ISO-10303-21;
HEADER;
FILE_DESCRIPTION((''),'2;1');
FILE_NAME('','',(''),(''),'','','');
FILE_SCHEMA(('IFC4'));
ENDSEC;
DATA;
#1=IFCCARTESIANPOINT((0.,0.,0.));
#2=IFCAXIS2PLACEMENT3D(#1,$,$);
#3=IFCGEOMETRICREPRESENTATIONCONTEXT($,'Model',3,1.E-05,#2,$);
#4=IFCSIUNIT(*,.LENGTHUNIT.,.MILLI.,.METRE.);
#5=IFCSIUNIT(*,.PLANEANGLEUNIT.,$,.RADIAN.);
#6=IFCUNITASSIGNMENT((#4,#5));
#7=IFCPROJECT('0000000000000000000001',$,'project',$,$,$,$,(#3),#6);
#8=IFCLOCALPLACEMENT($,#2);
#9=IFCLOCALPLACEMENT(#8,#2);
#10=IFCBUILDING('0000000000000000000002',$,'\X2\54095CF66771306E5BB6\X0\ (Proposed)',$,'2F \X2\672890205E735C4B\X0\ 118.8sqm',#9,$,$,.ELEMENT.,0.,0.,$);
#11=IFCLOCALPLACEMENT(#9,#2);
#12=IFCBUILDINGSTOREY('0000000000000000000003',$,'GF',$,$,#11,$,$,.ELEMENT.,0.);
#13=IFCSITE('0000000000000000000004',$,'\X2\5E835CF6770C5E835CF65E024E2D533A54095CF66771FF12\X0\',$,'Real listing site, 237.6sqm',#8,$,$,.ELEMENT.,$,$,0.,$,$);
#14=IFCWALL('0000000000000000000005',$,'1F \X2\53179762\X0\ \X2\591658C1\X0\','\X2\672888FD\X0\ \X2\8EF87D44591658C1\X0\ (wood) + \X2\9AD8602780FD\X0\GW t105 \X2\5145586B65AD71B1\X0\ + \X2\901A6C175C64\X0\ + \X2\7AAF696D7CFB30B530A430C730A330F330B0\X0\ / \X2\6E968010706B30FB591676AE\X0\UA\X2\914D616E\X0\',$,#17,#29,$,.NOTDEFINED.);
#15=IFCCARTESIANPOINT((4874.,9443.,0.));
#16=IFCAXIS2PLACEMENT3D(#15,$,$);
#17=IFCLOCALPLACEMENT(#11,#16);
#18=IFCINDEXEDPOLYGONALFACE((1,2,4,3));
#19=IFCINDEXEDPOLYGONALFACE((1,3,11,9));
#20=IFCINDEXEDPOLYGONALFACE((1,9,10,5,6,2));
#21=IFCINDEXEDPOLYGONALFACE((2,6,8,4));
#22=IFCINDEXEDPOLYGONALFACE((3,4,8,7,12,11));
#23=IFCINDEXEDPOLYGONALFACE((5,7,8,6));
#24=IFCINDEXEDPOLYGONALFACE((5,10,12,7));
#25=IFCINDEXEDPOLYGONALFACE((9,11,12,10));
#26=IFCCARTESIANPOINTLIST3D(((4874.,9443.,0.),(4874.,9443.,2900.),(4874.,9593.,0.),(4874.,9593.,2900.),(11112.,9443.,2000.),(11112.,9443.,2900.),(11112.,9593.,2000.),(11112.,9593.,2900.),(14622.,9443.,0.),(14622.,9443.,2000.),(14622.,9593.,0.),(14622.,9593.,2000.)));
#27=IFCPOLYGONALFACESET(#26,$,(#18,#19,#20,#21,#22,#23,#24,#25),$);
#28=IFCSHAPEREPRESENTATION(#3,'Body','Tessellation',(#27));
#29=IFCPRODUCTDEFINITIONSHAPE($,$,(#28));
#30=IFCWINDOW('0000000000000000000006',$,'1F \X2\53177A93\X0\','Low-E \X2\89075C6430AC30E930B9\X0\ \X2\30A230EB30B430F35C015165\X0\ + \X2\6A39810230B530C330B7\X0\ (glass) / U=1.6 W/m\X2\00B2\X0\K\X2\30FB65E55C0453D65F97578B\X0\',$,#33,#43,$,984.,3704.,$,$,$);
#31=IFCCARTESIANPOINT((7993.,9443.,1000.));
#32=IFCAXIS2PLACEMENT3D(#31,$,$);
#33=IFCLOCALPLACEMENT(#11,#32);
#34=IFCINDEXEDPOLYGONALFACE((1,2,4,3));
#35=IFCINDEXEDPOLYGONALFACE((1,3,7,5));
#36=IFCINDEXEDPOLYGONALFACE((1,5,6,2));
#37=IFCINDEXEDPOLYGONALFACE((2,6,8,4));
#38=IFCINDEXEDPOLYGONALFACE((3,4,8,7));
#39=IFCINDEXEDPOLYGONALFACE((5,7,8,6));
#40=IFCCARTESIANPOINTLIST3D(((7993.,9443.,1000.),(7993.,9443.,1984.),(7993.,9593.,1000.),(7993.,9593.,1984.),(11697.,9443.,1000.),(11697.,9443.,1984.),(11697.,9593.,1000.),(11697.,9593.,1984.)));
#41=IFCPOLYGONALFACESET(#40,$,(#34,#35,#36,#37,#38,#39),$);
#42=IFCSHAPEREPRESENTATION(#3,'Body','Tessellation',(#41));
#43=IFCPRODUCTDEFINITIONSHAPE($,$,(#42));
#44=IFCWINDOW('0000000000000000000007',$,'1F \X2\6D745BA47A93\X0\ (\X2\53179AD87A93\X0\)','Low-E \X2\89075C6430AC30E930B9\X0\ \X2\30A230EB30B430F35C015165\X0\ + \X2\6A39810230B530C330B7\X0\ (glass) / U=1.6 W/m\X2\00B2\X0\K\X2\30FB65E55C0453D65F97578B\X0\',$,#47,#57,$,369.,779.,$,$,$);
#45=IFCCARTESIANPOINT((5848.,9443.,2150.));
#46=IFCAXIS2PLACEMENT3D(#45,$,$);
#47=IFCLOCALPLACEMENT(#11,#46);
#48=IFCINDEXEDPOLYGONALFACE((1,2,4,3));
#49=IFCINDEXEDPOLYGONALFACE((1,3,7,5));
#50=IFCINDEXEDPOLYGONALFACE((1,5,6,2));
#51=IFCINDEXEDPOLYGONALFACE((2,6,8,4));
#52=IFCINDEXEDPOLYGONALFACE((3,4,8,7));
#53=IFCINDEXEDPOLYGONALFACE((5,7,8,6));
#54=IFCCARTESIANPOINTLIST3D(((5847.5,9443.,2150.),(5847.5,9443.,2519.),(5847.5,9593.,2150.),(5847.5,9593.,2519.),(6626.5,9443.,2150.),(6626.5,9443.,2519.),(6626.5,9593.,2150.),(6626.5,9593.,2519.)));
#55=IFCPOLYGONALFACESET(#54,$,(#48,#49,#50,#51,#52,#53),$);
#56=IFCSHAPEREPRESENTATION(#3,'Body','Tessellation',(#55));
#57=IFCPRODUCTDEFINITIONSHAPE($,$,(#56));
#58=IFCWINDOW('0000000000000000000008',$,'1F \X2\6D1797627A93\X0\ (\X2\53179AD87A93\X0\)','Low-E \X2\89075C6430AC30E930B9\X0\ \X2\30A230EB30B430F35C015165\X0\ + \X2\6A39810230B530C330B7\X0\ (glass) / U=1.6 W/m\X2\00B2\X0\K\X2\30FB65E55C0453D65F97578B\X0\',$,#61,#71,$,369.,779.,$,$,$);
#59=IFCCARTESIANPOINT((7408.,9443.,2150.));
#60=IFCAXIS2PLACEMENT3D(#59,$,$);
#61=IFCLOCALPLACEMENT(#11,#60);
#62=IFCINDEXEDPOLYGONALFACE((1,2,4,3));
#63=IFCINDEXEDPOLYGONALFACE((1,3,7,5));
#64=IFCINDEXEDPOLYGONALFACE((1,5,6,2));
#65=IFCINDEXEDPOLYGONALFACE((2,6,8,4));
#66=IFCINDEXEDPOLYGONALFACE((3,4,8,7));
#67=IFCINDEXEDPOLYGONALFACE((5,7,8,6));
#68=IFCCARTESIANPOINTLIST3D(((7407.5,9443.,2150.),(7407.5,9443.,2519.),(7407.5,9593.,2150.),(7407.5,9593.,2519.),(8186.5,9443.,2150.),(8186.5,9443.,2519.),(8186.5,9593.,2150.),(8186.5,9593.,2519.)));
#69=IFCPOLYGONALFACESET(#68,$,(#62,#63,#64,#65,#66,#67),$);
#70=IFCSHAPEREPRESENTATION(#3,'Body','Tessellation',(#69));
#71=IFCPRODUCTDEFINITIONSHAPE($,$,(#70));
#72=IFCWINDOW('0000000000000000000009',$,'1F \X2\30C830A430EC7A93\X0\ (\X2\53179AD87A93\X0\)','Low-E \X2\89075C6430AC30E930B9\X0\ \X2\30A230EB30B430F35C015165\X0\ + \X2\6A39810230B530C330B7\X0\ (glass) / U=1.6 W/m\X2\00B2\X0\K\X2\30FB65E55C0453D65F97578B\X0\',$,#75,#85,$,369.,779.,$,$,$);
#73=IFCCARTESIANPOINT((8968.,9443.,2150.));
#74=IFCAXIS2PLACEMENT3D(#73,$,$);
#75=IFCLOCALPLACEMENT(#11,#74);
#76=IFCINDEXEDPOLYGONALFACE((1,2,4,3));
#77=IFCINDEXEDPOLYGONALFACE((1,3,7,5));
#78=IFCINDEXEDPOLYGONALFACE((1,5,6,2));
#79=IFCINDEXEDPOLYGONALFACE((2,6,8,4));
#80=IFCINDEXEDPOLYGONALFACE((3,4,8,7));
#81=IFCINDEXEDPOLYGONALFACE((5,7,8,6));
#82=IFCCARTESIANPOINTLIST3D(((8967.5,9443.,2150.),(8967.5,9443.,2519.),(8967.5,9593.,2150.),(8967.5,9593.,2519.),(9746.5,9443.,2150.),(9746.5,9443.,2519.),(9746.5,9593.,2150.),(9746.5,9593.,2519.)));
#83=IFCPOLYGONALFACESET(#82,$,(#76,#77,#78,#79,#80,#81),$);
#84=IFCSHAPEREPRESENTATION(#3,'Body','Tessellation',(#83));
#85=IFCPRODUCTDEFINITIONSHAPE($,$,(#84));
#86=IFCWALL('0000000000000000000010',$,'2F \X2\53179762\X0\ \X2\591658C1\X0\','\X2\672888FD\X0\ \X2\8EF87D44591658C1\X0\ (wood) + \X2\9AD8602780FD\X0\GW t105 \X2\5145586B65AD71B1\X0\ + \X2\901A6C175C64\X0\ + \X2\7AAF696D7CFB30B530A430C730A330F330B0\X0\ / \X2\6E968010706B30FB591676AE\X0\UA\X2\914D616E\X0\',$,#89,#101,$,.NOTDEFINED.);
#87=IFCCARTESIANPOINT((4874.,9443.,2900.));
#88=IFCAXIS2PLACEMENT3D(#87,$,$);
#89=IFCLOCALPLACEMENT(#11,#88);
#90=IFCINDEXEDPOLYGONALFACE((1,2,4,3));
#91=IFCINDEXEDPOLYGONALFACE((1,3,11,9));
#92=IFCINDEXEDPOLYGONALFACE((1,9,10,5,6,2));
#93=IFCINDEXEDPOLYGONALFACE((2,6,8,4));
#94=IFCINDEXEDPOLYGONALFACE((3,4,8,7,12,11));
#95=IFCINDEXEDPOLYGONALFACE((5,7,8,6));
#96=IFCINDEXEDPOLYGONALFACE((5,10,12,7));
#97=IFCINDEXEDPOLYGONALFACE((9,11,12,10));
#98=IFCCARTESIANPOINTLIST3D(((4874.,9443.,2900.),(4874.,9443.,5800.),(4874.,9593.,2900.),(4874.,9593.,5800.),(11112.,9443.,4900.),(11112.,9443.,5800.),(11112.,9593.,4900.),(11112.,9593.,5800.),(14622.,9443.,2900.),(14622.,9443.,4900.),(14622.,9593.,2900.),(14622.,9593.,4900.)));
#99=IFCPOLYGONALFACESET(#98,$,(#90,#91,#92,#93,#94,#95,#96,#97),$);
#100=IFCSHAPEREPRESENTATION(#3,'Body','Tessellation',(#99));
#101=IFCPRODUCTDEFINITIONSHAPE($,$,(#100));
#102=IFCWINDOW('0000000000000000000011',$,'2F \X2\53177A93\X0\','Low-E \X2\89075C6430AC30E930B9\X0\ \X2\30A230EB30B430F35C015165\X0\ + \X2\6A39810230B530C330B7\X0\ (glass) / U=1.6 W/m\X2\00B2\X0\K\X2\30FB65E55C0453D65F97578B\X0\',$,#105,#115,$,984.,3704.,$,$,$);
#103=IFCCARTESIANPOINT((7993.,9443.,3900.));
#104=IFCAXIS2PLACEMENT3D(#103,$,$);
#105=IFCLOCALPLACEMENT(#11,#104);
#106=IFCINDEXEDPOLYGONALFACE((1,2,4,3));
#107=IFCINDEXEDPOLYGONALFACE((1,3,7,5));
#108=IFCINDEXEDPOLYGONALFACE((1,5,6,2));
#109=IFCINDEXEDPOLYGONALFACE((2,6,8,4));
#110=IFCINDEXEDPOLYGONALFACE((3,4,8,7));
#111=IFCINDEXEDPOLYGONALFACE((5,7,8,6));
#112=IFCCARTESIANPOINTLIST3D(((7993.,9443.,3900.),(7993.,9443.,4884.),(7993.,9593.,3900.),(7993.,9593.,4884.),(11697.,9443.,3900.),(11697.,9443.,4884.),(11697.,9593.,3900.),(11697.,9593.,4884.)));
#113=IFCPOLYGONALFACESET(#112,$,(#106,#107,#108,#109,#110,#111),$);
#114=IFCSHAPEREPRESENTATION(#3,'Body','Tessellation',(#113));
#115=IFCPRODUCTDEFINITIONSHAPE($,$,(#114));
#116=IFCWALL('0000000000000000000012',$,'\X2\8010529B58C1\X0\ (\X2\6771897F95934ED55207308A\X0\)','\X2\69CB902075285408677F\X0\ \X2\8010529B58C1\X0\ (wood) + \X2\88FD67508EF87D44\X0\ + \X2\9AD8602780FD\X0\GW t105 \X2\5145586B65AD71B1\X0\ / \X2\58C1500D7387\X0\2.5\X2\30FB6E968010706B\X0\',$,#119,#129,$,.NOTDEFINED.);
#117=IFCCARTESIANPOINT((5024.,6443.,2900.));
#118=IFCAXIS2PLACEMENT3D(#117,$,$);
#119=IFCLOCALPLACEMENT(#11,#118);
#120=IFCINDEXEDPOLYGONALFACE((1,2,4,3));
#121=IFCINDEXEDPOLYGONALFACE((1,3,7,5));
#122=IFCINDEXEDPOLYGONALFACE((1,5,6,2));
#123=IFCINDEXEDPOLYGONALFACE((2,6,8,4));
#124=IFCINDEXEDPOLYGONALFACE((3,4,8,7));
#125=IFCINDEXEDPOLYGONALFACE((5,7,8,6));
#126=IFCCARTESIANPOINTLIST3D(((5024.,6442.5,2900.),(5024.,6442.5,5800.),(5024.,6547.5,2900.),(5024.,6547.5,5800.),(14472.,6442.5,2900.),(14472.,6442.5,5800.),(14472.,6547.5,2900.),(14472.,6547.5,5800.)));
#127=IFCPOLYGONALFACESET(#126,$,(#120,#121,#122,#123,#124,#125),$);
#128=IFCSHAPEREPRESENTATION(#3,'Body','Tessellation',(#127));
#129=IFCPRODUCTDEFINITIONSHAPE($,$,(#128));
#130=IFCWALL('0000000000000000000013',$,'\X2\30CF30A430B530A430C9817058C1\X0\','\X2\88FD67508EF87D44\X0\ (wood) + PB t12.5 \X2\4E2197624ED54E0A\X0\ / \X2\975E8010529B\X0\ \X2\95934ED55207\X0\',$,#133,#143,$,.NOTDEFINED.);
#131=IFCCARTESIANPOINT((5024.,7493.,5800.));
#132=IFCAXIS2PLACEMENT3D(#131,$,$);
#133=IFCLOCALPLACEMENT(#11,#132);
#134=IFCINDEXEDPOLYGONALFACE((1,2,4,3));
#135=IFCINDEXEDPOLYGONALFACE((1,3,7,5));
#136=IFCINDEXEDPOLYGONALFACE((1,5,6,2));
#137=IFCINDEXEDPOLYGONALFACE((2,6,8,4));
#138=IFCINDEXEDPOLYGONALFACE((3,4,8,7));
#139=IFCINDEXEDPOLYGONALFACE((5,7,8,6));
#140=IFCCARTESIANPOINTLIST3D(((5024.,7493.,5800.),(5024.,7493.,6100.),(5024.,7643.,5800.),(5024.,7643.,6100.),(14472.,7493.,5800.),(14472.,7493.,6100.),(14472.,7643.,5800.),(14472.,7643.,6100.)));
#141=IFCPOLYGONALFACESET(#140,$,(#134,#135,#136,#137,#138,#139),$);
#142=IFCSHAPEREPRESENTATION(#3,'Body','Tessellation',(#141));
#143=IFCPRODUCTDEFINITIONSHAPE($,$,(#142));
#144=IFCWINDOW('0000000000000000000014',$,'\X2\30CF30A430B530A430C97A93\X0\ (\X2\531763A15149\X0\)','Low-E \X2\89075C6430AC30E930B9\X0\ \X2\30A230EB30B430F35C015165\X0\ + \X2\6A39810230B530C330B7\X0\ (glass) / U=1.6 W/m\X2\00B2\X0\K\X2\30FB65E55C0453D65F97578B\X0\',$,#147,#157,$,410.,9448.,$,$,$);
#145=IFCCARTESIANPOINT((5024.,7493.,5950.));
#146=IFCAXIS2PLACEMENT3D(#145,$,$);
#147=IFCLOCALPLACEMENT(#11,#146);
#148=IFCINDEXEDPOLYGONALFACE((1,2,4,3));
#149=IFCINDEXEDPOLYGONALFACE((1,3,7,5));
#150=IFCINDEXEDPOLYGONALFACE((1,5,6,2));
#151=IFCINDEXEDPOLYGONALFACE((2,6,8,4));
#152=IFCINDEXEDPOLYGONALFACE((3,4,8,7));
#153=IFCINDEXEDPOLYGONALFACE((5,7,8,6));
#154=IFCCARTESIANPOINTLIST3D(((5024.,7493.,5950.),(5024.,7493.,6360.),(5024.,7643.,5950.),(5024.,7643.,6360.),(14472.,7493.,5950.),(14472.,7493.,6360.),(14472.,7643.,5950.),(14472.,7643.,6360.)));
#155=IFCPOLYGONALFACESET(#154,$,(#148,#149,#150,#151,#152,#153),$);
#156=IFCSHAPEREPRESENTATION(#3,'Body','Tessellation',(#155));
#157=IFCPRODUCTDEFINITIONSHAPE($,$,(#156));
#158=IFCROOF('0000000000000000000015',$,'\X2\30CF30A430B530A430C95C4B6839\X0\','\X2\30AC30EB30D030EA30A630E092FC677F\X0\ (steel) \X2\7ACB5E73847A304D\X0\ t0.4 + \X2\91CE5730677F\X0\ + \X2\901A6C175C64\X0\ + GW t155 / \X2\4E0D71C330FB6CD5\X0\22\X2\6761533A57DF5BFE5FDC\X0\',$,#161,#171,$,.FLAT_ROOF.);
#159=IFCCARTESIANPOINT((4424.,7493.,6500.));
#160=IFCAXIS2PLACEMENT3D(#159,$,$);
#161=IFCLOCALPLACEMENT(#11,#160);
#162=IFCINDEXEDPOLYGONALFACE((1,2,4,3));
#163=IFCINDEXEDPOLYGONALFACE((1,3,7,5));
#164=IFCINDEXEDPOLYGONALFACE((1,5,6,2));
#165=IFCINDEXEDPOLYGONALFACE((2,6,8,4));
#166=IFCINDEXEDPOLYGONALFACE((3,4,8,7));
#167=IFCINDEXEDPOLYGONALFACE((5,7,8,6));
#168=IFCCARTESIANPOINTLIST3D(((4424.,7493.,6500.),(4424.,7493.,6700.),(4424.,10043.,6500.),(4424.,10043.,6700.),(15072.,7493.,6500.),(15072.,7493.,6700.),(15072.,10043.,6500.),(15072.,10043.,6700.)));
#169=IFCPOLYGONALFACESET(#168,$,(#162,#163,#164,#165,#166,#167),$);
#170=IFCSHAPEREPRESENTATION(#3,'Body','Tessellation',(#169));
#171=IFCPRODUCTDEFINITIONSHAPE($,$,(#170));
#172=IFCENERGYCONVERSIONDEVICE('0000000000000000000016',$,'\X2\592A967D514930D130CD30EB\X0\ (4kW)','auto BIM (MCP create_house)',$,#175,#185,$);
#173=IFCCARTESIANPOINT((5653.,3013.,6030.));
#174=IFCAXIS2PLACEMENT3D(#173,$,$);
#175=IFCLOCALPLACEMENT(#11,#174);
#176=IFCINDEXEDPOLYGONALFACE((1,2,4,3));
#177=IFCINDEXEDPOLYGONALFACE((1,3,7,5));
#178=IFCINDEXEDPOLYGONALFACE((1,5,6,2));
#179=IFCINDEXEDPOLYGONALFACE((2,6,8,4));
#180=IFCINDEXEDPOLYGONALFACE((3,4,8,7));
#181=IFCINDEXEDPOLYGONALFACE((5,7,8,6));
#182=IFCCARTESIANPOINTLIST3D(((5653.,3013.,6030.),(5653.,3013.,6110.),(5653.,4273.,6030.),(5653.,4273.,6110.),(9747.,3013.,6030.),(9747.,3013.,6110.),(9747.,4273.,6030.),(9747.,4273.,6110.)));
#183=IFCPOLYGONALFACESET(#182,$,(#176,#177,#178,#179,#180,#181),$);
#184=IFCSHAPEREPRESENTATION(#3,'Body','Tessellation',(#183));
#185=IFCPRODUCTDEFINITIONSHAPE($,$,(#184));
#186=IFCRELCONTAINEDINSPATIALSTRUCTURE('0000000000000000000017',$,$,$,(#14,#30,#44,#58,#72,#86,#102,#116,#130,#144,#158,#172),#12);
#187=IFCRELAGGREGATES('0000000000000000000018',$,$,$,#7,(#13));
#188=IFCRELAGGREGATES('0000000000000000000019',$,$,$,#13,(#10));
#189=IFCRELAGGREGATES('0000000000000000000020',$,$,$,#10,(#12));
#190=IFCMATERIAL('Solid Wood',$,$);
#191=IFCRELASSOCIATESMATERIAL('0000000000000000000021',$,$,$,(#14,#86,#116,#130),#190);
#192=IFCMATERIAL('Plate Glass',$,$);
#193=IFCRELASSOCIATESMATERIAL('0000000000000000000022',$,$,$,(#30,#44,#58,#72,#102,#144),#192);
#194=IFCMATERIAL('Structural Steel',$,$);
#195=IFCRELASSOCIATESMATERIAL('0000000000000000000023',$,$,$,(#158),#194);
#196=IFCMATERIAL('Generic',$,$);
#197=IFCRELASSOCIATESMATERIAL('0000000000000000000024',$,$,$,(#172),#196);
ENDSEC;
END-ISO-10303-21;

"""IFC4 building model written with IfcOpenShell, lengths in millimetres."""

from ifc_helpers import new_model, si_unit, frame, frame_2d, origin, place, context, project, spatial, rectangle, extrude, material, element, fill, save


model = new_model("IFC4")

# Units and contexts
model_context = context("Model", 3, precision=1e-05, world=origin())
ifc_project = project(units=[si_unit("LENGTHUNIT", "METRE", prefix="MILLI"), si_unit("PLANEANGLEUNIT", "RADIAN")], contexts=[model_context])

# Site, building, storey
site_placement = place(None, origin())
site = spatial("IfcSite", under=ifc_project, at=site_placement, Name="広島県広島市中区吉島東２", ObjectType="Real listing site, 237.6sqm", CompositionType="ELEMENT", RefElevation=0.0)
building_placement = place(site_placement, origin())
building = spatial("IfcBuilding", under=site, at=building_placement, Name="吉島東の家 (Proposed)", ObjectType="2F 木造平屋 118.8sqm", CompositionType="ELEMENT", ElevationOfRefHeight=0.0, ElevationOfTerrain=0.0)
storey_placement = place(building_placement, origin())
storey = spatial("IfcBuildingStorey", under=building, at=storey_placement, Name="GF", CompositionType="ELEMENT", Elevation=0.0)

# Wall, openings, windows
ifc_material_1 = material(Name="Solid Wood")
wall_1_placement = place(storey_placement, frame((4874.0, 9443.0, 0.0)))
wall_1 = element("IfcWall", 1, at=wall_1_placement, inside=storey, material=ifc_material_1, Name="1F 北面 外壁", Description="木製 軸組外壁 (wood) + 高性能GW t105 充填断熱 + 通気層 + 窯業系サイディング / 準耐火・外皮UA配慮", PredefinedType="NOTDEFINED", context=model_context, shape_type="SweptSolid", body=[
    extrude(rectangle(XDim=9748.0, YDim=150.0, at=frame_2d((4874.0, 75.0))), frame((4874.0, 9443.0, 0.0)), (0.0, 0.0, 1.0), 2900.0),
])
opening_1_placement = place(storey_placement, frame((7993.0, 9443.0, 1000.0)))
opening_1 = element("IfcOpeningElement", 2, at=opening_1_placement, cuts=wall_1, PredefinedType="NOTDEFINED", context=model_context, shape_type="SweptSolid", body=[
    extrude(rectangle(XDim=3704.0, YDim=150.0, at=frame_2d((1852.0, 75.0))), frame((7993.0, 9443.0, 1000.0)), (0.0, 0.0, 1.0), 984.0),
])
opening_2_placement = place(storey_placement, frame((5848.0, 9443.0, 2150.0)))
opening_2 = element("IfcOpeningElement", 3, at=opening_2_placement, cuts=wall_1, PredefinedType="NOTDEFINED", context=model_context, shape_type="SweptSolid", body=[
    extrude(rectangle(XDim=779.0, YDim=150.0, at=frame_2d((389.0, 75.0))), frame((5848.0, 9443.0, 2150.0)), (0.0, 0.0, 1.0), 369.0),
])
opening_3_placement = place(storey_placement, frame((7408.0, 9443.0, 2150.0)))
opening_3 = element("IfcOpeningElement", 4, at=opening_3_placement, cuts=wall_1, PredefinedType="NOTDEFINED", context=model_context, shape_type="SweptSolid", body=[
    extrude(rectangle(XDim=779.0, YDim=150.0, at=frame_2d((389.0, 75.0))), frame((7408.0, 9443.0, 2150.0)), (0.0, 0.0, 1.0), 369.0),
])
opening_4_placement = place(storey_placement, frame((8968.0, 9443.0, 2150.0)))
opening_4 = element("IfcOpeningElement", 5, at=opening_4_placement, cuts=wall_1, PredefinedType="NOTDEFINED", context=model_context, shape_type="SweptSolid", body=[
    extrude(rectangle(XDim=779.0, YDim=150.0, at=frame_2d((389.0, 75.0))), frame((8968.0, 9443.0, 2150.0)), (0.0, 0.0, 1.0), 369.0),
])
ifc_material_2 = material(Name="Plate Glass")
window_1_placement = place(storey_placement, frame((7993.0, 9443.0, 1000.0)))
window_1 = element("IfcWindow", 6, at=window_1_placement, inside=storey, material=ifc_material_2, Name="1F 北窓", Description="Low-E 複層ガラス アルゴン封入 + 樹脂サッシ (glass) / U=1.6 W/m²K・日射取得型", OverallHeight=984.0, OverallWidth=3704.0, context=model_context, shape_type="SweptSolid", body=[
    extrude(rectangle(XDim=3704.0, YDim=150.0, at=frame_2d((1852.0, 75.0))), frame((7993.0, 9443.0, 1000.0)), (0.0, 0.0, 1.0), 984.0),
])
fill(opening_1, window_1)
window_2_placement = place(storey_placement, frame((5848.0, 9443.0, 2150.0)))
window_2 = element("IfcWindow", 7, at=window_2_placement, inside=storey, material=ifc_material_2, Name="1F 浴室窓 (北高窓)", Description="Low-E 複層ガラス アルゴン封入 + 樹脂サッシ (glass) / U=1.6 W/m²K・日射取得型", OverallHeight=369.0, OverallWidth=779.0, context=model_context, shape_type="SweptSolid", body=[
    extrude(rectangle(XDim=779.0, YDim=150.0, at=frame_2d((389.0, 75.0))), frame((5848.0, 9443.0, 2150.0)), (0.0, 0.0, 1.0), 369.0),
])
fill(opening_2, window_2)
window_3_placement = place(storey_placement, frame((7408.0, 9443.0, 2150.0)))
window_3 = element("IfcWindow", 8, at=window_3_placement, inside=storey, material=ifc_material_2, Name="1F 洗面窓 (北高窓)", Description="Low-E 複層ガラス アルゴン封入 + 樹脂サッシ (glass) / U=1.6 W/m²K・日射取得型", OverallHeight=369.0, OverallWidth=779.0, context=model_context, shape_type="SweptSolid", body=[
    extrude(rectangle(XDim=779.0, YDim=150.0, at=frame_2d((389.0, 75.0))), frame((7408.0, 9443.0, 2150.0)), (0.0, 0.0, 1.0), 369.0),
])
fill(opening_3, window_3)
window_4_placement = place(storey_placement, frame((8968.0, 9443.0, 2150.0)))
window_4 = element("IfcWindow", 9, at=window_4_placement, inside=storey, material=ifc_material_2, Name="1F トイレ窓 (北高窓)", Description="Low-E 複層ガラス アルゴン封入 + 樹脂サッシ (glass) / U=1.6 W/m²K・日射取得型", OverallHeight=369.0, OverallWidth=779.0, context=model_context, shape_type="SweptSolid", body=[
    extrude(rectangle(XDim=779.0, YDim=150.0, at=frame_2d((389.0, 75.0))), frame((8968.0, 9443.0, 2150.0)), (0.0, 0.0, 1.0), 369.0),
])
fill(opening_4, window_4)

# Wall, opening, window
wall_2_placement = place(storey_placement, frame((4874.0, 9443.0, 2900.0)))
wall_2 = element("IfcWall", 10, at=wall_2_placement, inside=storey, material=ifc_material_1, Name="2F 北面 外壁", Description="木製 軸組外壁 (wood) + 高性能GW t105 充填断熱 + 通気層 + 窯業系サイディング / 準耐火・外皮UA配慮", PredefinedType="NOTDEFINED", context=model_context, shape_type="SweptSolid", body=[
    extrude(rectangle(XDim=9748.0, YDim=150.0, at=frame_2d((4874.0, 75.0))), frame((4874.0, 9443.0, 2900.0)), (0.0, 0.0, 1.0), 2900.0),
])
opening_5_placement = place(storey_placement, frame((7993.0, 9443.0, 3900.0)))
opening_5 = element("IfcOpeningElement", 11, at=opening_5_placement, cuts=wall_2, PredefinedType="NOTDEFINED", context=model_context, shape_type="SweptSolid", body=[
    extrude(rectangle(XDim=3704.0, YDim=150.0, at=frame_2d((1852.0, 75.0))), frame((7993.0, 9443.0, 3900.0)), (0.0, 0.0, 1.0), 984.0),
])
window_5_placement = place(storey_placement, frame((7993.0, 9443.0, 3900.0)))
window_5 = element("IfcWindow", 12, at=window_5_placement, inside=storey, material=ifc_material_2, Name="2F 北窓", Description="Low-E 複層ガラス アルゴン封入 + 樹脂サッシ (glass) / U=1.6 W/m²K・日射取得型", OverallHeight=984.0, OverallWidth=3704.0, context=model_context, shape_type="SweptSolid", body=[
    extrude(rectangle(XDim=3704.0, YDim=150.0, at=frame_2d((1852.0, 75.0))), frame((7993.0, 9443.0, 3900.0)), (0.0, 0.0, 1.0), 984.0),
])
fill(opening_5, window_5)

# Wall
wall_3_placement = place(storey_placement, frame((5024.0, 6443.0, 2900.0)))
element("IfcWall", 13, at=wall_3_placement, inside=storey, material=ifc_material_1, Name="耐力壁 (東西間仕切り)", Description="構造用合板 耐力壁 (wood) + 製材軸組 + 高性能GW t105 充填断熱 / 壁倍率2.5・準耐火", PredefinedType="NOTDEFINED", context=model_context, shape_type="SweptSolid", body=[
    extrude(rectangle(XDim=9448.0, YDim=105.0, at=frame_2d((4724.0, 52.0))), frame((5024.0, 6443.0, 2900.0)), (0.0, 0.0, 1.0), 2900.0),
])

# Wall, opening, window
wall_4_placement = place(storey_placement, frame((5024.0, 7493.0, 5800.0)))
wall_4 = element("IfcWall", 14, at=wall_4_placement, inside=storey, material=ifc_material_1, Name="ハイサイド腰壁", Description="製材軸組 (wood) + PB t12.5 両面仕上 / 非耐力 間仕切", PredefinedType="NOTDEFINED", context=model_context, shape_type="SweptSolid", body=[
    extrude(rectangle(XDim=9448.0, YDim=150.0, at=frame_2d((4724.0, 75.0))), frame((5024.0, 7493.0, 5800.0)), (0.0, 0.0, 1.0), 700.0),
])
opening_6_placement = place(storey_placement, frame((5024.0, 7493.0, 5950.0)))
opening_6 = element("IfcOpeningElement", 15, at=opening_6_placement, cuts=wall_4, PredefinedType="NOTDEFINED", context=model_context, shape_type="SweptSolid", body=[
    extrude(rectangle(XDim=9448.0, YDim=150.0, at=frame_2d((4724.0, 75.0))), frame((5024.0, 7493.0, 5950.0)), (0.0, 0.0, 1.0), 410.0),
])
window_6_placement = place(storey_placement, frame((5024.0, 7493.0, 5950.0)))
window_6 = element("IfcWindow", 16, at=window_6_placement, inside=storey, material=ifc_material_2, Name="ハイサイド窓 (北採光)", Description="Low-E 複層ガラス アルゴン封入 + 樹脂サッシ (glass) / U=1.6 W/m²K・日射取得型", OverallHeight=410.0, OverallWidth=9448.0, context=model_context, shape_type="SweptSolid", body=[
    extrude(rectangle(XDim=9448.0, YDim=150.0, at=frame_2d((4724.0, 75.0))), frame((5024.0, 7493.0, 5950.0)), (0.0, 0.0, 1.0), 410.0),
])
fill(opening_6, window_6)

# Roof
ifc_material_3 = material(Name="Structural Steel")
roof_placement = place(storey_placement, frame((4424.0, 7493.0, 6500.0)))
element("IfcRoof", 17, at=roof_placement, inside=storey, material=ifc_material_3, Name="ハイサイド屋根", Description="ガルバリウム鋼板 (steel) 立平葺き t0.4 + 野地板 + 通気層 + GW t155 / 不燃・法22条区域対応", PredefinedType="FLAT_ROOF", context=model_context, shape_type="SweptSolid", body=[
    extrude(rectangle(XDim=10648.0, YDim=2550.0, at=frame_2d((5324.0, 1275.0))), frame((4424.0, 7493.0, 6500.0)), (0.0, 0.0, 1.0), 200.0),
])

# Energy conversion device
ifc_material_4 = material(Name="Generic")
energy_conversion_device_placement = place(storey_placement, frame((5653.0, 3013.0, 6030.0)))
element("IfcEnergyConversionDevice", 18, at=energy_conversion_device_placement, inside=storey, material=ifc_material_4, Name="太陽光パネル (4kW)", Description="auto BIM (MCP create_house)", context=model_context, shape_type="SweptSolid", body=[
    extrude(rectangle(XDim=4094.0, YDim=1260.0, at=frame_2d((2047.0, 630.0))), frame((5653.0, 3013.0, 6030.0)), (0.0, 0.0, 1.0), 80.0),
])

save(model, "model.ifc")
